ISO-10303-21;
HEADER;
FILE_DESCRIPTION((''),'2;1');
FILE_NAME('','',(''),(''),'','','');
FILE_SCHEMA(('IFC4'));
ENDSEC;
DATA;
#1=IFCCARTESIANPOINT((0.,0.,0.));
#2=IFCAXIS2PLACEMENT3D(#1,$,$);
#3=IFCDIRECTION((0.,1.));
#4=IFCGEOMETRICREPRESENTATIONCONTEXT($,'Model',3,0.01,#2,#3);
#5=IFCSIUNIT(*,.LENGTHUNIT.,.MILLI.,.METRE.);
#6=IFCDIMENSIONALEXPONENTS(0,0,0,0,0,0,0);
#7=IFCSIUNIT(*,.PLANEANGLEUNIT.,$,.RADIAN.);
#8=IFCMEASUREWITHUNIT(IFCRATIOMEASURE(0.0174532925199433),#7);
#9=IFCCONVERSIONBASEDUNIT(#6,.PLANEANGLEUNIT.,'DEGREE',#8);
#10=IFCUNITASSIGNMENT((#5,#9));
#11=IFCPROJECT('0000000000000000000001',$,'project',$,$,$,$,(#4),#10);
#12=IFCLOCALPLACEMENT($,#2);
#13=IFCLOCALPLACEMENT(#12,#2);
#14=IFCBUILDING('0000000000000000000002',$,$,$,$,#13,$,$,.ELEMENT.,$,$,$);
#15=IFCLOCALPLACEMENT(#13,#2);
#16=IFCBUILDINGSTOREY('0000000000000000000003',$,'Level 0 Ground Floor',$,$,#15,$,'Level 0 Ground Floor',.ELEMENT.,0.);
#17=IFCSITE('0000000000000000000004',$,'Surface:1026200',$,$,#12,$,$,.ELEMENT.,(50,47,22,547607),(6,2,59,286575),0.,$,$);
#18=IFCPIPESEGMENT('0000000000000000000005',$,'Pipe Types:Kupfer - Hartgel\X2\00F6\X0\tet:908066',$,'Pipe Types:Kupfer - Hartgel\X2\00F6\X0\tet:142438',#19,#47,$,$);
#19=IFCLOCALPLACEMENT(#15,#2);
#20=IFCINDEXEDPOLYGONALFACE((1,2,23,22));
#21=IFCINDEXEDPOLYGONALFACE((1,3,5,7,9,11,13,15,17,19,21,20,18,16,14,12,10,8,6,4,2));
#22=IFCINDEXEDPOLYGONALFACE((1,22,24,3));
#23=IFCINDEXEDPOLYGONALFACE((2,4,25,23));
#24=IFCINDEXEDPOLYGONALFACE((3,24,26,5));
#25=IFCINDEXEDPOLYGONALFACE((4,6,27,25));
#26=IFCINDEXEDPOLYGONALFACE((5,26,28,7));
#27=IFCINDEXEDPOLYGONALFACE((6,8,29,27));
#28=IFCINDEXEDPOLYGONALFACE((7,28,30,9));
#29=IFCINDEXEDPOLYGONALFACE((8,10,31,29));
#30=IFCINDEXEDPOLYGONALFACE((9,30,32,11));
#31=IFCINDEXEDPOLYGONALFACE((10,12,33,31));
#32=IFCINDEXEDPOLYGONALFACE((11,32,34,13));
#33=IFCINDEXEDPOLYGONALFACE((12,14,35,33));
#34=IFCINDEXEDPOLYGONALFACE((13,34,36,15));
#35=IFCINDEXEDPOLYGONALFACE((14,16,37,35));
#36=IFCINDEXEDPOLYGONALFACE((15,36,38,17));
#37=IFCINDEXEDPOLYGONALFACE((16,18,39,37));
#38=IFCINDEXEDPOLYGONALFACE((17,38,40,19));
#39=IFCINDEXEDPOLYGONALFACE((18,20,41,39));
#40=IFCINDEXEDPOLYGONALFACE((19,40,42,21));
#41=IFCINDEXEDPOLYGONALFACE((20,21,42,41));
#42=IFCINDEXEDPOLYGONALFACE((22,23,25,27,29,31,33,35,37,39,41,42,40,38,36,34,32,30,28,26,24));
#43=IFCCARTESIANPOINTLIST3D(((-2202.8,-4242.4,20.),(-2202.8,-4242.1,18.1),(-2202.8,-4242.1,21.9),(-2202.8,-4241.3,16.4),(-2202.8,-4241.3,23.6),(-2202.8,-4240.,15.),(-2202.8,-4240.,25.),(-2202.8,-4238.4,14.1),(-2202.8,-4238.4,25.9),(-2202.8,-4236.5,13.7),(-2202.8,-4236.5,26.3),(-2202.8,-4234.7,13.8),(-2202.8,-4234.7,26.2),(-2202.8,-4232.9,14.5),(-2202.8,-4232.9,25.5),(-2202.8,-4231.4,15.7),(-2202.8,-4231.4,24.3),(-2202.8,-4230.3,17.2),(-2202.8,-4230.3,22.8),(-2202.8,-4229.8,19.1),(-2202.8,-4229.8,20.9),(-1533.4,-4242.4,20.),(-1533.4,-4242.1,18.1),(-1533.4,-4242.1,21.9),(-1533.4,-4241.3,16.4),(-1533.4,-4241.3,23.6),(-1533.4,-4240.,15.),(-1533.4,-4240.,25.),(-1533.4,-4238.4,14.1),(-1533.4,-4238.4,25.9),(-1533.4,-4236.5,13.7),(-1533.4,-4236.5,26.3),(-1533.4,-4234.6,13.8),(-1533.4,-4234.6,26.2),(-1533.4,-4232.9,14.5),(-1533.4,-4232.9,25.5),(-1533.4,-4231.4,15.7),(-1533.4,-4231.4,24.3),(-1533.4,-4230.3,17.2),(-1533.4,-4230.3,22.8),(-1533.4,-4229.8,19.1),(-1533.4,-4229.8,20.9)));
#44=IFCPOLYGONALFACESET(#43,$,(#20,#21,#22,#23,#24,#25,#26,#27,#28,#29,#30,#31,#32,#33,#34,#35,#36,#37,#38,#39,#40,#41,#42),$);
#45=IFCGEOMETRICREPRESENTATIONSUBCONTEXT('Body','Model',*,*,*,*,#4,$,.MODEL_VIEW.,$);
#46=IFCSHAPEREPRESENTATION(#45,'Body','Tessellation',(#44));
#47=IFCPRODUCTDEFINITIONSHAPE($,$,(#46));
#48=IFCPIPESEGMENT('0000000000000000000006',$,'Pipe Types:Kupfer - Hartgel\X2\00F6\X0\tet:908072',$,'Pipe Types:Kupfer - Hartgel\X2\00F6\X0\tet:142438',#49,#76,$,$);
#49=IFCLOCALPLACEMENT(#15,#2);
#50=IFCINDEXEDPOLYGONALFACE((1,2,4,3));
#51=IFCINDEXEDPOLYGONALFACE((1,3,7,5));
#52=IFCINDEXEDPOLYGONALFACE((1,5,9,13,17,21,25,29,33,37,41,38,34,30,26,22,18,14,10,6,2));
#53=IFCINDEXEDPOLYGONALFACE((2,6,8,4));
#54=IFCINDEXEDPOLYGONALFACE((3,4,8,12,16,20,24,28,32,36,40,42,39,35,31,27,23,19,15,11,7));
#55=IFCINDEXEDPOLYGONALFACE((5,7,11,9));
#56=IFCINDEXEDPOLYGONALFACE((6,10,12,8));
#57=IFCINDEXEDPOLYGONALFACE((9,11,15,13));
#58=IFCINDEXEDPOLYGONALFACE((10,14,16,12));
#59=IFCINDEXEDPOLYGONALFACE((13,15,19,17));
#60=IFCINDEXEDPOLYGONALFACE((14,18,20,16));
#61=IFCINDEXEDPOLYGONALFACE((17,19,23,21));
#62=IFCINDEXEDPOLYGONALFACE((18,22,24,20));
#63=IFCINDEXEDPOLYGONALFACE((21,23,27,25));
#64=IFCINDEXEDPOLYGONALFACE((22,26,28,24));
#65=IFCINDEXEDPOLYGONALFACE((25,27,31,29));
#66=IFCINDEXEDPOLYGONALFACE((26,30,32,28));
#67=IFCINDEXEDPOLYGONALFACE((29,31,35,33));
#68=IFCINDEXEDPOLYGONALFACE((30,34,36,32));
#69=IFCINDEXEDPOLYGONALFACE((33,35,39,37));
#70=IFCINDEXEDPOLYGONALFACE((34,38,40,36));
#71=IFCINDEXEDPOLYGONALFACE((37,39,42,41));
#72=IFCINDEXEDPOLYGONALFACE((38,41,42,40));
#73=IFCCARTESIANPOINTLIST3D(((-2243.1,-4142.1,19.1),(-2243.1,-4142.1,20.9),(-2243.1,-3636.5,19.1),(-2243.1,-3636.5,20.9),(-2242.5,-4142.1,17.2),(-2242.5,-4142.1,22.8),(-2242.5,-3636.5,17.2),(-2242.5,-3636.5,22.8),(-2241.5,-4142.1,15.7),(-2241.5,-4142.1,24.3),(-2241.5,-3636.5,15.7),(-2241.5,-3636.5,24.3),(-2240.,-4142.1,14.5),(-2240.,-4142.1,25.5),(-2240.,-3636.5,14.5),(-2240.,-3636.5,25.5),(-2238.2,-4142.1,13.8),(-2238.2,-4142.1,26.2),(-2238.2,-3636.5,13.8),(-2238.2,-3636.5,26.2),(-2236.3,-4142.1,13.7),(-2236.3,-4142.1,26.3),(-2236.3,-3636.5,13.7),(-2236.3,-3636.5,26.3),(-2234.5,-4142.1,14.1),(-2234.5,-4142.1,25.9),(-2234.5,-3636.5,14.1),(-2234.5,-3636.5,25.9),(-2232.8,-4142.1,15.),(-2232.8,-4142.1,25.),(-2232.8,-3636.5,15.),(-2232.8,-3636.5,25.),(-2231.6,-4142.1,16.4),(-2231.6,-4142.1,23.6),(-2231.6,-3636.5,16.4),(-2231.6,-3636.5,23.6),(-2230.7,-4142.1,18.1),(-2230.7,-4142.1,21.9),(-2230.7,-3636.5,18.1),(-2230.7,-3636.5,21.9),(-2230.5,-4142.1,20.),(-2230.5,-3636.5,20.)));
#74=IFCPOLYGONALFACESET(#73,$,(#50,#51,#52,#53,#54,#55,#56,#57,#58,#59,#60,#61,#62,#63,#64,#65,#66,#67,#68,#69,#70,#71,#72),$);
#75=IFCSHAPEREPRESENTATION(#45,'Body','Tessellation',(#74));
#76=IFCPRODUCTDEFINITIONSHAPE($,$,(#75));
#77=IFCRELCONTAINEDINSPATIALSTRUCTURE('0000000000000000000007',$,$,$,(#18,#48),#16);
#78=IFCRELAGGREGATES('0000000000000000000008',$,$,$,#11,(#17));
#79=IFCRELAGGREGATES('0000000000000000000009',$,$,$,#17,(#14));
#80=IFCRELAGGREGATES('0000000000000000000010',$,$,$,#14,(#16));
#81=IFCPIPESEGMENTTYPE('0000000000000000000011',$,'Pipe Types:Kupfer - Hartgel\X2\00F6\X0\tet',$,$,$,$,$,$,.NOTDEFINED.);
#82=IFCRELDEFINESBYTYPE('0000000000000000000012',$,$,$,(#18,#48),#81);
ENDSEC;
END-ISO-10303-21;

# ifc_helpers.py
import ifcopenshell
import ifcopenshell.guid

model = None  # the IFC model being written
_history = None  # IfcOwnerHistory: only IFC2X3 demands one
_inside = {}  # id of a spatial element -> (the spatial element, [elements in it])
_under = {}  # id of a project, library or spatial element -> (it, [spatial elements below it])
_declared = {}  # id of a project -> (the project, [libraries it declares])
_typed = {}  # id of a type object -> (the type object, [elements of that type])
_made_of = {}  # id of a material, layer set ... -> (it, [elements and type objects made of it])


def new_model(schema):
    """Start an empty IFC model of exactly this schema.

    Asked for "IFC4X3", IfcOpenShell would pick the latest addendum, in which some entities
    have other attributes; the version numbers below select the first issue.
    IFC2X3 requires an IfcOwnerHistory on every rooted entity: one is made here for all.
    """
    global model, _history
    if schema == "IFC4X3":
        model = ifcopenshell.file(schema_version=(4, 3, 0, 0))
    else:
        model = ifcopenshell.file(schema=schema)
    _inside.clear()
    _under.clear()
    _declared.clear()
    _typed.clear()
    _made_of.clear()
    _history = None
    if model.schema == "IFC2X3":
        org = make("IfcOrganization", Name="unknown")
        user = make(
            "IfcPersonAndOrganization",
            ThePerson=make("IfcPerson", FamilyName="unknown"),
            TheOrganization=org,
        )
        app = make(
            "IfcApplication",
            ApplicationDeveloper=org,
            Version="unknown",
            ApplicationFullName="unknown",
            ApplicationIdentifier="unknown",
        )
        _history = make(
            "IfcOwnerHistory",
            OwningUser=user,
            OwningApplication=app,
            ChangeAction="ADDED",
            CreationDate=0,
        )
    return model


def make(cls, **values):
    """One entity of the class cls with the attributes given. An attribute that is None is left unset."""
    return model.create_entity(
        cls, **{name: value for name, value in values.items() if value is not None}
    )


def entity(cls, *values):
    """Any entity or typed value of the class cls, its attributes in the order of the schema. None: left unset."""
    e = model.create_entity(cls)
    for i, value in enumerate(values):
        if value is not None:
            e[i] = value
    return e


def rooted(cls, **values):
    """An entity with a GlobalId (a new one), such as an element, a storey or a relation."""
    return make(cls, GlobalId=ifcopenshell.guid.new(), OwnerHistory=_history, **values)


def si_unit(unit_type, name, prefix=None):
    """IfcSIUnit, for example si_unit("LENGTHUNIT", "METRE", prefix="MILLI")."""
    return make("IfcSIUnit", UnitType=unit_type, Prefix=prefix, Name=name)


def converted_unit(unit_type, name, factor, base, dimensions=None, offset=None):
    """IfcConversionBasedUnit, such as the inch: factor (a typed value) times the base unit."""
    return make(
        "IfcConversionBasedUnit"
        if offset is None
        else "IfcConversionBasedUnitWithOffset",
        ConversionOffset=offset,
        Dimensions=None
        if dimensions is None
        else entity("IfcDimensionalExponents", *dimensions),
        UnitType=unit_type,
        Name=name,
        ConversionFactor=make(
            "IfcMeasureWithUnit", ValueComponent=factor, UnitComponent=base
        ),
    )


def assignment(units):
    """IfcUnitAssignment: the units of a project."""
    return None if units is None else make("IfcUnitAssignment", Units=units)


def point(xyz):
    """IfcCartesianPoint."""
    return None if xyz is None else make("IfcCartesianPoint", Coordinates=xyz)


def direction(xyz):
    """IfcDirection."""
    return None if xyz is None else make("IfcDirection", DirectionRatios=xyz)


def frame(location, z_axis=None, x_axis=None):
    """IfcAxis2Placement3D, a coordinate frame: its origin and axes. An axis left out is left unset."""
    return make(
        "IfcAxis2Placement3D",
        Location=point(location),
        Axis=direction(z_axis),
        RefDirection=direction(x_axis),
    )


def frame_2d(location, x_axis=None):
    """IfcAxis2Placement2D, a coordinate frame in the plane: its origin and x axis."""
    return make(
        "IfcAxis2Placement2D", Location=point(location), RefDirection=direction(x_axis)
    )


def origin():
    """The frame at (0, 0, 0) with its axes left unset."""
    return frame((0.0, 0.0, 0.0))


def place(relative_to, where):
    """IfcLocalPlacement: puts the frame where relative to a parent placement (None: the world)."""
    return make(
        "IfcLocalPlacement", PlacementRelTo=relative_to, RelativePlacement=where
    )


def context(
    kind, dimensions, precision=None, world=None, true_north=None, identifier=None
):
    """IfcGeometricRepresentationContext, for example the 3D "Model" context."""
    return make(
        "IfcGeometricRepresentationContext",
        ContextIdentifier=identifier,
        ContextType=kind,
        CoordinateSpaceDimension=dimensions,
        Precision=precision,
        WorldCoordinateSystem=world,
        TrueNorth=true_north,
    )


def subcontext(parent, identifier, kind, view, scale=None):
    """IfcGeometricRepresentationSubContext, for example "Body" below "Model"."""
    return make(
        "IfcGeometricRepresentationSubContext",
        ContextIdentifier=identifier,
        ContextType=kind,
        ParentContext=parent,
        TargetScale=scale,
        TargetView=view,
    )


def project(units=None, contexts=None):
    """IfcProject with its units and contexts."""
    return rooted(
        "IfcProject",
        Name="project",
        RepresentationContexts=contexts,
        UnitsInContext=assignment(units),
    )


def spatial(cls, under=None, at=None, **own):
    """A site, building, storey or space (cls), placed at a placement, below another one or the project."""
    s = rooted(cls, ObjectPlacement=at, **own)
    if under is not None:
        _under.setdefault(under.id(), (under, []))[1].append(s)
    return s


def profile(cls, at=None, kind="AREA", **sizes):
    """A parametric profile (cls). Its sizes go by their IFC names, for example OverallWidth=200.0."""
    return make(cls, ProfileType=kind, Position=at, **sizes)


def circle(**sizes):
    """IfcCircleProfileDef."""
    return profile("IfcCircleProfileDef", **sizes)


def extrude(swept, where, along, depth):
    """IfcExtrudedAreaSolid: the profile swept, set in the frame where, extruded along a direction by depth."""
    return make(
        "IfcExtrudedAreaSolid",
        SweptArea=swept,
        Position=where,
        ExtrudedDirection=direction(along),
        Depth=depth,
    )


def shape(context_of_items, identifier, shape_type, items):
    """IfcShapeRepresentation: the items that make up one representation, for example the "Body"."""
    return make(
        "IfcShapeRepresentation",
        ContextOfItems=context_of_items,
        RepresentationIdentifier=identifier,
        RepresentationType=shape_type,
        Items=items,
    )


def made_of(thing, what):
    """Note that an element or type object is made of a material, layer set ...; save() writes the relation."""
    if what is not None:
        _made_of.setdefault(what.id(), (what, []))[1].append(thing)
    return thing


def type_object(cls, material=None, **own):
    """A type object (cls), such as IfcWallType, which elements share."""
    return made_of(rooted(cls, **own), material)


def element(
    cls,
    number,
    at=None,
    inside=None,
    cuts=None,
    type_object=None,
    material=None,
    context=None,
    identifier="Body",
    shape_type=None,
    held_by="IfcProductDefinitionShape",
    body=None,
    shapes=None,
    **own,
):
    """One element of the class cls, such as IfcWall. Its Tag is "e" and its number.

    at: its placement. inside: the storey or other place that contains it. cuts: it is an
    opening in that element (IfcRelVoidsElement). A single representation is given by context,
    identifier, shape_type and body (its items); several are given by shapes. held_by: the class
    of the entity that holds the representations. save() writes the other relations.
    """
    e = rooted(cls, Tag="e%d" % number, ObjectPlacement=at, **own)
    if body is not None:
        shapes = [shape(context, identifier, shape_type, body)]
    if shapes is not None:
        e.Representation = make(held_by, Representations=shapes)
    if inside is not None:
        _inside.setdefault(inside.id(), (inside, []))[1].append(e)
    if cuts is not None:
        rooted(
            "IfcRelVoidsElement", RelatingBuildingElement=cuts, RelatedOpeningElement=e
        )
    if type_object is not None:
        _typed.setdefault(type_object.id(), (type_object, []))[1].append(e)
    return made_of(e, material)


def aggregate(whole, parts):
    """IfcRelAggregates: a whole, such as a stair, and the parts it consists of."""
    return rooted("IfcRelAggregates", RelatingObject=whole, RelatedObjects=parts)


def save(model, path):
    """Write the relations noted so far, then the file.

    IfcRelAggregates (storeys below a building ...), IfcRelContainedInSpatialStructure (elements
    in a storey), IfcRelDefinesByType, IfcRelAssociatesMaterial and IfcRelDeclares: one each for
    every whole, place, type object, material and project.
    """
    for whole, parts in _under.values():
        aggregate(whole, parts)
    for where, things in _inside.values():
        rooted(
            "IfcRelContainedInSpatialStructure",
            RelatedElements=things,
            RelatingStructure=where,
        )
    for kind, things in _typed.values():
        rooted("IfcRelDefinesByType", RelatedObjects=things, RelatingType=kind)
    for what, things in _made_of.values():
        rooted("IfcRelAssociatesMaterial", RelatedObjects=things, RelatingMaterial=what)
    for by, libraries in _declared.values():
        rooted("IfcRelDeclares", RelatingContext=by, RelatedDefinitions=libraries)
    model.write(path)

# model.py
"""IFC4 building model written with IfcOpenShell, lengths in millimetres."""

from ifc_helpers import new_model, entity, si_unit, converted_unit, direction, frame, frame_2d, origin, place, context, subcontext, project, spatial, circle, extrude, type_object, element, save


model = new_model("IFC4")

# Units and contexts
model_context = context("Model", 3, precision=0.01, world=origin(), true_north=direction((0.0, 1.0)))
body_context = subcontext(model_context, "Body", "Model", "MODEL_VIEW")
ifc_project = project(units=[si_unit("LENGTHUNIT", "METRE", prefix="MILLI"), converted_unit("PLANEANGLEUNIT", "DEGREE", entity("IfcRatioMeasure", 0.0174532925199433), si_unit("PLANEANGLEUNIT", "RADIAN"), dimensions=[0, 0, 0, 0, 0, 0, 0])], contexts=[model_context])

# Site, building, storey
site_placement = place(None, origin())
site = spatial("IfcSite", under=ifc_project, at=site_placement, Name="Surface:1026200", CompositionType="ELEMENT", RefLatitude=(50, 47, 22, 547607), RefLongitude=(6, 2, 59, 286575), RefElevation=0.0)
building_placement = place(site_placement, origin())
building = spatial("IfcBuilding", under=site, at=building_placement, CompositionType="ELEMENT")
storey_placement = place(building_placement, origin())
storey = spatial("IfcBuildingStorey", under=building, at=storey_placement, Name="Level 0 Ground Floor", LongName="Level 0 Ground Floor", CompositionType="ELEMENT", Elevation=0.0)

# Pipe segments
pipe_segment_type = type_object("IfcPipeSegmentType", Name="Pipe Types:Kupfer - Hartgelötet", PredefinedType="NOTDEFINED")
pipe_segment_1_placement = place(storey_placement, frame((-2202.8, -4244.0, 12.1)))
element("IfcPipeSegment", 1, at=pipe_segment_1_placement, inside=storey, type_object=pipe_segment_type, Name="Pipe Types:Kupfer - Hartgelötet:908066", ObjectType="Pipe Types:Kupfer - Hartgelötet:142438", context=body_context, shape_type="SweptSolid", body=[
    extrude(circle(Radius=6.3, at=frame_2d((0.0, 0.0), x_axis=(1.0, 0.0))), frame((0.0, 7.9, 7.9), z_axis=(1.0, 0.000044, 0.0), x_axis=(0.000044, -1.0, 0.0)), (0.0, 0.0, 1.0), 669.4),
])
pipe_segment_2_placement = place(storey_placement, frame((-2244.8, -4142.1, 12.1)))
element("IfcPipeSegment", 2, at=pipe_segment_2_placement, inside=storey, type_object=pipe_segment_type, Name="Pipe Types:Kupfer - Hartgelötet:908072", ObjectType="Pipe Types:Kupfer - Hartgelötet:142438", context=body_context, shape_type="SweptSolid", body=[
    extrude(circle(Radius=6.3, at=frame_2d((0.0, 0.0), x_axis=(1.0, 0.0))), frame((7.9, 0.0, 7.9), z_axis=(0.0, 1.0, 0.0), x_axis=(1.0, 0.0, 0.0)), (0.0, 0.0, 1.0), 505.5),
])

save(model, "model.ifc")
